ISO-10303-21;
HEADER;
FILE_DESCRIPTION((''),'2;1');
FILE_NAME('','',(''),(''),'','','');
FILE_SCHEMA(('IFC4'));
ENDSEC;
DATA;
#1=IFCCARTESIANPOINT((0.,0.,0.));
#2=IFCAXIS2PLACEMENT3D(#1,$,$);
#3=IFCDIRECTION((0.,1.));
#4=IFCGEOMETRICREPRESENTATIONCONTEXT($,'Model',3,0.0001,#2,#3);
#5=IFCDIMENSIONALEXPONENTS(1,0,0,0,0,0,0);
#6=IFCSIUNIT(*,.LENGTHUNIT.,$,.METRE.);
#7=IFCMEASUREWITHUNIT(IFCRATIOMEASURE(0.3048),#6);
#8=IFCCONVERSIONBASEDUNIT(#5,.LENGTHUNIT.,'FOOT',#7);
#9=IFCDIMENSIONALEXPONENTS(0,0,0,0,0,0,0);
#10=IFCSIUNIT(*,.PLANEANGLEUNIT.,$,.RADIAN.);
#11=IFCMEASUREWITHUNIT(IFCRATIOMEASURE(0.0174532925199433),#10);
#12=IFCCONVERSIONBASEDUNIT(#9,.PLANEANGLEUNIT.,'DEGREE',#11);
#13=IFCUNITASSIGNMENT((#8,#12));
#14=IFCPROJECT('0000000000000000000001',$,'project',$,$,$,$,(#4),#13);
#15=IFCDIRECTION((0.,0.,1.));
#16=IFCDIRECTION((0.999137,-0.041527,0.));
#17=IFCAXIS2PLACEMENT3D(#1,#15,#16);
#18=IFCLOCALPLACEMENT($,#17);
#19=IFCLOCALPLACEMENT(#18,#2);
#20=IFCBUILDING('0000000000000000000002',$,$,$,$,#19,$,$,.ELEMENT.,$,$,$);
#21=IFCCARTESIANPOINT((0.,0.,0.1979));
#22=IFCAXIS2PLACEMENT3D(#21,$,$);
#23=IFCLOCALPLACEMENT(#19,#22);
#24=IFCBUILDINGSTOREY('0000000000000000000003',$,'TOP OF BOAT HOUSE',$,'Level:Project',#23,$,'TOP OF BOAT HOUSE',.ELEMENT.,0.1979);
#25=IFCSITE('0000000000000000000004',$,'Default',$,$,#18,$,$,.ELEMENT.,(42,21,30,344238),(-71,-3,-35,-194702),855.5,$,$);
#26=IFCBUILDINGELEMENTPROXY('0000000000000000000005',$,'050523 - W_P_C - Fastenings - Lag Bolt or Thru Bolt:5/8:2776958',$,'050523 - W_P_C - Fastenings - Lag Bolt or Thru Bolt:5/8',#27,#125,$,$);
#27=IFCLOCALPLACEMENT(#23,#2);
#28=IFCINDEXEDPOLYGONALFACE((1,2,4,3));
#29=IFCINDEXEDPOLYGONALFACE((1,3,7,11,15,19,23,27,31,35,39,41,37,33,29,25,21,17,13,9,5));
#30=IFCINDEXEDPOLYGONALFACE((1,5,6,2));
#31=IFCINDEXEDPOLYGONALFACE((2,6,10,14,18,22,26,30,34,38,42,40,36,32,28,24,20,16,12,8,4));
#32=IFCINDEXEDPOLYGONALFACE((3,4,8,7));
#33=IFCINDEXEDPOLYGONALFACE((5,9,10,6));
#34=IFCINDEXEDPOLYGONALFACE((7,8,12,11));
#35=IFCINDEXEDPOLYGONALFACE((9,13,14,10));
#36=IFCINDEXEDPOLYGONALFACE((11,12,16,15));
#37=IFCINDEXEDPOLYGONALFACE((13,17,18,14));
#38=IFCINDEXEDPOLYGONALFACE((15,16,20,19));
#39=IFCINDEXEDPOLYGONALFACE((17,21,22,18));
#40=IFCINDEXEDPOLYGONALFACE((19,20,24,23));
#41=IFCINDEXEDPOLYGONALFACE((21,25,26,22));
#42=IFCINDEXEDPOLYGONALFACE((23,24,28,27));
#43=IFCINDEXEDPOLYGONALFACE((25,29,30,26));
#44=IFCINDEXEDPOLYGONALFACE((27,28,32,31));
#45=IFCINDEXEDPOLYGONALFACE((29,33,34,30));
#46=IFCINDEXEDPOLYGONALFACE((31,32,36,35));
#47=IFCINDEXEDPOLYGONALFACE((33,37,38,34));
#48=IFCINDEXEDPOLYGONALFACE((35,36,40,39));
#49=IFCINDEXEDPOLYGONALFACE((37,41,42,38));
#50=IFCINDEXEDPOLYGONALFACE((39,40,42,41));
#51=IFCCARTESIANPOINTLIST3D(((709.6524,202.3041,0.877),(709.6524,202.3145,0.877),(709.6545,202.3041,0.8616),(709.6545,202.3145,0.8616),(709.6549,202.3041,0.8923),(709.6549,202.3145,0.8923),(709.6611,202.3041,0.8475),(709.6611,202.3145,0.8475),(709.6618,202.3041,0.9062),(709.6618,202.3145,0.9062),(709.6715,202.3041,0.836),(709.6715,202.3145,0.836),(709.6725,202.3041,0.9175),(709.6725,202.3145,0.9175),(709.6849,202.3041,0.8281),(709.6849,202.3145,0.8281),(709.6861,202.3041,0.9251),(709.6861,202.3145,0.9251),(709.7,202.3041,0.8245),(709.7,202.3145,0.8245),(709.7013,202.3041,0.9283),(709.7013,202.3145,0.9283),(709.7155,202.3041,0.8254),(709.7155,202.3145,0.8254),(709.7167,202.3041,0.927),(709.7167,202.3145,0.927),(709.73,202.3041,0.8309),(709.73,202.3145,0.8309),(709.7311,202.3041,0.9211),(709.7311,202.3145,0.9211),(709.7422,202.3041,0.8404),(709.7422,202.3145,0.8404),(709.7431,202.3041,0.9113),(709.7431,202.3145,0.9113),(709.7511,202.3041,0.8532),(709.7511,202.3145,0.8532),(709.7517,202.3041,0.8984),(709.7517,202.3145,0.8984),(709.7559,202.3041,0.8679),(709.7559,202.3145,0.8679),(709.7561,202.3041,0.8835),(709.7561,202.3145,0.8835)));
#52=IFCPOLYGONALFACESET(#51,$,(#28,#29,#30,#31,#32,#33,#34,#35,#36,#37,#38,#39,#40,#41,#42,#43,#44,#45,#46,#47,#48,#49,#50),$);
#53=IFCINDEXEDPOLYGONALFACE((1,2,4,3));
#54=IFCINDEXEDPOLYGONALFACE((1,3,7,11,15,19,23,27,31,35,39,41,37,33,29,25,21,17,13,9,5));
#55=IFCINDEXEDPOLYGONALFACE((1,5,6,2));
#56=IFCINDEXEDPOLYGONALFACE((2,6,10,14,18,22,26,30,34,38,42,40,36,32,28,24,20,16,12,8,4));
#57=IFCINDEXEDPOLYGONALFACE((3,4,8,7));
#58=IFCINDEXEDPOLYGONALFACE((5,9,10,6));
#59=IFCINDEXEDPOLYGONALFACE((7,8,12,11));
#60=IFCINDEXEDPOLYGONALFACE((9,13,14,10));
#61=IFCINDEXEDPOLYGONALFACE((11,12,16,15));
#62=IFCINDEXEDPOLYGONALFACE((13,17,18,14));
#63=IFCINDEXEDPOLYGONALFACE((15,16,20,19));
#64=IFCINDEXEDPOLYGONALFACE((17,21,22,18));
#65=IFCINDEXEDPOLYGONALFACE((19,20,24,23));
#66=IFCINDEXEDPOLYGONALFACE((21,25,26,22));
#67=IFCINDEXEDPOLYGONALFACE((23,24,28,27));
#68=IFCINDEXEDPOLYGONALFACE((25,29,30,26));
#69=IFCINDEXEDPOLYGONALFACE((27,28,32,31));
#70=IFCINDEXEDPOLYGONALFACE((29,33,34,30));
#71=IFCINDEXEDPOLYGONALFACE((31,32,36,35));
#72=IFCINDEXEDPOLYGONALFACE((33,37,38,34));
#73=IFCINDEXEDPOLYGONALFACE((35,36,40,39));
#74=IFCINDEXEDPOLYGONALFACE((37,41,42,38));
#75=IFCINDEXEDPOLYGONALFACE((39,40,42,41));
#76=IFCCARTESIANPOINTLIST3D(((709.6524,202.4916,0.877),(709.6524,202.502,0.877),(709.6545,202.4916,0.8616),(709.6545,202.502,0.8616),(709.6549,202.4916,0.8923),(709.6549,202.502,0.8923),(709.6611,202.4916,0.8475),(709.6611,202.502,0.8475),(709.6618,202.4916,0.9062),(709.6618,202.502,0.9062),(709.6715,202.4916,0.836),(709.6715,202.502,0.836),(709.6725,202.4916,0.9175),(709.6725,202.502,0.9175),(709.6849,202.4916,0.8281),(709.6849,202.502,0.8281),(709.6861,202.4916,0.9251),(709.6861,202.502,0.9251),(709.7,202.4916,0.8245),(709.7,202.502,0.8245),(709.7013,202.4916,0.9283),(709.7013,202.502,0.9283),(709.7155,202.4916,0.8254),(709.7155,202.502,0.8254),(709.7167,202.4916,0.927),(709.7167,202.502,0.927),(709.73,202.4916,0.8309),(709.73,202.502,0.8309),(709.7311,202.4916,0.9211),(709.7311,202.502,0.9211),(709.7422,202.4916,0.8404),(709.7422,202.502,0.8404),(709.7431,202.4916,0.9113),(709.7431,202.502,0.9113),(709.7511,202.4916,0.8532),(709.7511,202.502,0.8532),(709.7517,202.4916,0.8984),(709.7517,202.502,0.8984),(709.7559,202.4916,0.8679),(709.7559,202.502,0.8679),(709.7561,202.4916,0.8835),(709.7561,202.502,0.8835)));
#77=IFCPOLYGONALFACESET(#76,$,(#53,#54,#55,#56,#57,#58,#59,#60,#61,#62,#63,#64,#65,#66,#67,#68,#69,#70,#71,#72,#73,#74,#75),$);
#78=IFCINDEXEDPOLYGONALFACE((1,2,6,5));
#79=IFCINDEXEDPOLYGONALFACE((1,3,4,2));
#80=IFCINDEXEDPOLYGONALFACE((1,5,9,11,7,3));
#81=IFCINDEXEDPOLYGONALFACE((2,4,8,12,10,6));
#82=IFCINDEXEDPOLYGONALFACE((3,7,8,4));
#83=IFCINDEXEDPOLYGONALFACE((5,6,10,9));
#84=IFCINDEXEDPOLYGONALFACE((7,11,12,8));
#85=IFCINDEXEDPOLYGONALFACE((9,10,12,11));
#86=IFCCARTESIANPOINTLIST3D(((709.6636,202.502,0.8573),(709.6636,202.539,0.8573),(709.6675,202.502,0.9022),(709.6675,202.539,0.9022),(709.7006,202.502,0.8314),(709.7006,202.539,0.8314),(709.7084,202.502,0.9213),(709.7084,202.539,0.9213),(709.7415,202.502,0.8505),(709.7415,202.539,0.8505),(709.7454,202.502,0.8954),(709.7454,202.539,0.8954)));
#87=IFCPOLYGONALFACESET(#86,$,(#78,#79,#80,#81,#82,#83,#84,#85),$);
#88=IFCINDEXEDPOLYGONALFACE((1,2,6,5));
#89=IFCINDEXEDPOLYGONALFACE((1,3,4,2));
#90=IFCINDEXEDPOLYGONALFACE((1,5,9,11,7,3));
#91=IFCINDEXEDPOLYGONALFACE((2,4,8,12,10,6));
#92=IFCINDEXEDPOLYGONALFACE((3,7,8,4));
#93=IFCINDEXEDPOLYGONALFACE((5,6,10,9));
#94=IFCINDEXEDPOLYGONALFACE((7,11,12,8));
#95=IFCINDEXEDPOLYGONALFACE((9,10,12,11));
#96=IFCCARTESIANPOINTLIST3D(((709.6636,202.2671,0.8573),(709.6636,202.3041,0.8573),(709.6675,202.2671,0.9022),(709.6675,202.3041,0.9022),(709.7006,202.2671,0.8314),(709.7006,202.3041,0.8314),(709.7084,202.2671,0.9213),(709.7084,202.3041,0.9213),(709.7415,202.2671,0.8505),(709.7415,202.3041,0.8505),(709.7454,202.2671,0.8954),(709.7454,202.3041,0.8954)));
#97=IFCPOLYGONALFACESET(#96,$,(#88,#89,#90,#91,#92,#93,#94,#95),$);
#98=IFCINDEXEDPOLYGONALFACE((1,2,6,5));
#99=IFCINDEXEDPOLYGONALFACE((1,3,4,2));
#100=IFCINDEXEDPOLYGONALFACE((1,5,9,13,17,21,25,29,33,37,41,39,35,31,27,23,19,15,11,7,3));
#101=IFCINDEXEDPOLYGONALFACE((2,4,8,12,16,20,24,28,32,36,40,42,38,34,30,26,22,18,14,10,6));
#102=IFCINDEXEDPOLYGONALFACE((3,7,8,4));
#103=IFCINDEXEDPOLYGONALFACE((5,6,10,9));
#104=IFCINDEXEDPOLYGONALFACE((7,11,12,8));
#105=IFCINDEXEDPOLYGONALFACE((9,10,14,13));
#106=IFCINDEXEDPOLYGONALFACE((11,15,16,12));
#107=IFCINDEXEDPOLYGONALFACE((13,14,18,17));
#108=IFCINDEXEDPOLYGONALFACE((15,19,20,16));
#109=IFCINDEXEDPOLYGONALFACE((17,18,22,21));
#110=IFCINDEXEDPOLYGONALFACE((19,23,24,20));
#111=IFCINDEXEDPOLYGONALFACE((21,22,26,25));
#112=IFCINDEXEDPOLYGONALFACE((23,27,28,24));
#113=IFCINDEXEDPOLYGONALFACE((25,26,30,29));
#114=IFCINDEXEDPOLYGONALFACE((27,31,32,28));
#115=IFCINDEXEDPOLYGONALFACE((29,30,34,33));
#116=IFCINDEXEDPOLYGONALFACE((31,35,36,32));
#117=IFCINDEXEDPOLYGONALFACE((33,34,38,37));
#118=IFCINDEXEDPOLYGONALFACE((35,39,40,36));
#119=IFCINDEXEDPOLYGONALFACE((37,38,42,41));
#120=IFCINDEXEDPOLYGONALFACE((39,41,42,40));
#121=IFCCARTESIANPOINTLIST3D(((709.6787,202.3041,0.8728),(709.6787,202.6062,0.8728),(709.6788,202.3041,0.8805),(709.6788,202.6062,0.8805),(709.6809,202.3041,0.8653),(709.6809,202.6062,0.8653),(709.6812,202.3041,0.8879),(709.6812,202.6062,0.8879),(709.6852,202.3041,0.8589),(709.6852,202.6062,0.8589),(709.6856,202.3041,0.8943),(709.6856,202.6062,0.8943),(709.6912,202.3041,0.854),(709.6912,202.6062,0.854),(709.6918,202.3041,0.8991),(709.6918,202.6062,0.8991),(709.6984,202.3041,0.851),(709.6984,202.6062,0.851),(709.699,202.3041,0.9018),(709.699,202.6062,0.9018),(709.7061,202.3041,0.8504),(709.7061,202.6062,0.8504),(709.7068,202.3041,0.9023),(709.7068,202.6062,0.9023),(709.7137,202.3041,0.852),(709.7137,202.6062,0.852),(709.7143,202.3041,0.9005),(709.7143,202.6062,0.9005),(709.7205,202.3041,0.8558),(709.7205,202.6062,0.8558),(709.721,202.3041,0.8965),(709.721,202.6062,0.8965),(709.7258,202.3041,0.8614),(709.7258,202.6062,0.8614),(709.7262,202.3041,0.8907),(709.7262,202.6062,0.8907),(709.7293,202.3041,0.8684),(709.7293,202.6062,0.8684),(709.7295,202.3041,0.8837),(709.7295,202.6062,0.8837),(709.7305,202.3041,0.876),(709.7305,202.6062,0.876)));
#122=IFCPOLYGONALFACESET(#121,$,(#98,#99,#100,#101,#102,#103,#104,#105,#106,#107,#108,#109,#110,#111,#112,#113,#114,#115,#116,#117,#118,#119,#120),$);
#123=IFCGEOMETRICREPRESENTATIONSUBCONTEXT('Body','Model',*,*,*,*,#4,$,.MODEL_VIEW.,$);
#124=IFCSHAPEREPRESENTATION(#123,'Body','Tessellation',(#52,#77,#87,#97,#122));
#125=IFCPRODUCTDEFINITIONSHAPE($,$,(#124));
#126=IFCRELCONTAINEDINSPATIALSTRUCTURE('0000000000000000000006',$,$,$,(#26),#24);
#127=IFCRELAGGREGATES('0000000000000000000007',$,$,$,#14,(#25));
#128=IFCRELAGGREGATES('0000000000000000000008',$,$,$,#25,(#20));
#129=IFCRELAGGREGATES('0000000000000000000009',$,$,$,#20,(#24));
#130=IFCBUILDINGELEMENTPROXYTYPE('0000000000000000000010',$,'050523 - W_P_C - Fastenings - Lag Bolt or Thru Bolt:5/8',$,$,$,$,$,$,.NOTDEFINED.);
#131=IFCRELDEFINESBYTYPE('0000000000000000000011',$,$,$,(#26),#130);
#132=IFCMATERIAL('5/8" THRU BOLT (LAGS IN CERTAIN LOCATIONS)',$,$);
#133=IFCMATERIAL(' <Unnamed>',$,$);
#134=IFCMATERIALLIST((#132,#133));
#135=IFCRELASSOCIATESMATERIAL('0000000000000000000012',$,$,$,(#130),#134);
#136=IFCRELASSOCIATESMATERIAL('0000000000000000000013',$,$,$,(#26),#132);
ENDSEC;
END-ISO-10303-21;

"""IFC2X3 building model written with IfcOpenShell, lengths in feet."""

from ifc_helpers import new_model, entity, si_unit, converted_unit, direction, frame, frame_2d, origin, place, context, subcontext, project, spatial, polyline, circle, outline, extrude, source, transform, mapped, material, material_list, type_object, type_shapes, element, save


model = new_model("IFC2X3")

# Units and contexts
model_context = context("Model", 3, precision=0.0001, world=origin(), true_north=direction((0.0, 1.0)))
body_context = subcontext(model_context, "Body", "Model", "MODEL_VIEW")
ifc_project = project(units=[converted_unit("LENGTHUNIT", "FOOT", entity("IfcRatioMeasure", 0.3048), si_unit("LENGTHUNIT", "METRE"), dimensions=[1, 0, 0, 0, 0, 0, 0]), converted_unit("PLANEANGLEUNIT", "DEGREE", entity("IfcRatioMeasure", 0.0174532925199433), si_unit("PLANEANGLEUNIT", "RADIAN"), dimensions=[0, 0, 0, 0, 0, 0, 0])], contexts=[model_context])

# Site, building, storey
site_placement = place(None, frame((0.0, 0.0, 0.0), z_axis=(0.0, 0.0, 1.0), x_axis=(0.999137, -0.041527, 0.0)))
site = spatial("IfcSite", under=ifc_project, at=site_placement, Name="Default", CompositionType="ELEMENT", RefLatitude=(42, 21, 30, 344238), RefLongitude=(-71, -3, -35, -194702), RefElevation=855.5)
building_placement = place(site_placement, origin())
building = spatial("IfcBuilding", under=site, at=building_placement, CompositionType="ELEMENT")
storey_placement = place(building_placement, frame((0.0, 0.0, 0.1979)))
storey = spatial("IfcBuildingStorey", under=building, at=storey_placement, Name="TOP OF BOAT HOUSE", ObjectType="Level:Project", LongName="TOP OF BOAT HOUSE", CompositionType="ELEMENT", Elevation=0.1979)

# Building element proxy
ifc_material_1 = material(Name="5/8\" THRU BOLT (LAGS IN CERTAIN LOCATIONS)")
ifc_material_2 = material(Name=" <Unnamed>")
ifc_material_list_1 = material_list([ifc_material_1, ifc_material_2])
building_element_proxy_type_1 = type_object("IfcBuildingElementProxyType", Name="050523 - W_P_C - Fastenings - Lag Bolt or Thru Bolt:5/8", PredefinedType="NOTDEFINED", material=ifc_material_list_1)
shared_shape_1 = source(origin(), body_context, "Body", "SweptSolid", [
    extrude(circle(Radius=0.0521, at=frame_2d((0.0, 0.0), x_axis=(1.0, 0.0))), frame((0.0, 0.0, 0.0), z_axis=(0.0, 0.0, 1.0), x_axis=(0.0, -1.0, 0.0)), (0.0, 0.0, 1.0), 0.0104),
    extrude(circle(Radius=0.0521, at=frame_2d((0.0, 0.0), x_axis=(1.0, 0.0))), frame((0.0, 0.0, -0.1875), z_axis=(0.0, 0.0, 1.0), x_axis=(0.0, -1.0, 0.0)), (0.0, 0.0, 1.0), 0.0104),
    extrude(outline(polyline([(-0.0226, -0.0391), (0.0226, -0.0391), (0.0451, 0.0), (0.0226, 0.0391), (-0.0226, 0.0391), (-0.0451, 0.0), (-0.0226, -0.0391)])), frame((0.0, 0.0, -0.2245), z_axis=(0.0, 0.0, 1.0), x_axis=(0.866025, -0.5, 0.0)), (0.0, 0.0, 1.0), 0.037),
    extrude(outline(polyline([(-0.0226, -0.0391), (0.0226, -0.0391), (0.0451, 0.0), (0.0226, 0.0391), (-0.0226, 0.0391), (-0.0451, 0.0), (-0.0226, -0.0391)])), frame((0.0, 0.0, 0.0104), z_axis=(0.0, 0.0, 1.0), x_axis=(0.0, -1.0, 0.0)), (0.0, 0.0, 1.0), 0.037),
    extrude(circle(Radius=0.026, at=frame_2d((0.0, 0.0), x_axis=(1.0, 0.0))), frame((0.0, 0.0, -0.2917), z_axis=(0.0, 0.0, 1.0), x_axis=(0.0, 1.0, 0.0)), (0.0, 0.0, 1.0), 0.3021),
])
type_shapes(building_element_proxy_type_1, [shared_shape_1])
for number, where, z_axis, x_axis, name in (
    (1, (709.7045, 202.3145, 0.8763), (0.0, -1.0, 0.0), (0.996195, 0.0, -0.087156), "050523 - W_P_C - Fastenings - Lag Bolt or Thru Bolt:5/8:2776958"),
):
    element("IfcBuildingElementProxy", number, at=place(storey_placement, frame(where, z_axis=z_axis, x_axis=x_axis)), inside=storey, type_object=building_element_proxy_type_1, material=ifc_material_1, Name=name, ObjectType="050523 - W_P_C - Fastenings - Lag Bolt or Thru Bolt:5/8", context=body_context, shape_type="MappedRepresentation", body=[
        mapped(shared_shape_1, transform((0.0, 0.0, 0.0), scale=1.0)),
    ])

save(model, "model.ifc")
